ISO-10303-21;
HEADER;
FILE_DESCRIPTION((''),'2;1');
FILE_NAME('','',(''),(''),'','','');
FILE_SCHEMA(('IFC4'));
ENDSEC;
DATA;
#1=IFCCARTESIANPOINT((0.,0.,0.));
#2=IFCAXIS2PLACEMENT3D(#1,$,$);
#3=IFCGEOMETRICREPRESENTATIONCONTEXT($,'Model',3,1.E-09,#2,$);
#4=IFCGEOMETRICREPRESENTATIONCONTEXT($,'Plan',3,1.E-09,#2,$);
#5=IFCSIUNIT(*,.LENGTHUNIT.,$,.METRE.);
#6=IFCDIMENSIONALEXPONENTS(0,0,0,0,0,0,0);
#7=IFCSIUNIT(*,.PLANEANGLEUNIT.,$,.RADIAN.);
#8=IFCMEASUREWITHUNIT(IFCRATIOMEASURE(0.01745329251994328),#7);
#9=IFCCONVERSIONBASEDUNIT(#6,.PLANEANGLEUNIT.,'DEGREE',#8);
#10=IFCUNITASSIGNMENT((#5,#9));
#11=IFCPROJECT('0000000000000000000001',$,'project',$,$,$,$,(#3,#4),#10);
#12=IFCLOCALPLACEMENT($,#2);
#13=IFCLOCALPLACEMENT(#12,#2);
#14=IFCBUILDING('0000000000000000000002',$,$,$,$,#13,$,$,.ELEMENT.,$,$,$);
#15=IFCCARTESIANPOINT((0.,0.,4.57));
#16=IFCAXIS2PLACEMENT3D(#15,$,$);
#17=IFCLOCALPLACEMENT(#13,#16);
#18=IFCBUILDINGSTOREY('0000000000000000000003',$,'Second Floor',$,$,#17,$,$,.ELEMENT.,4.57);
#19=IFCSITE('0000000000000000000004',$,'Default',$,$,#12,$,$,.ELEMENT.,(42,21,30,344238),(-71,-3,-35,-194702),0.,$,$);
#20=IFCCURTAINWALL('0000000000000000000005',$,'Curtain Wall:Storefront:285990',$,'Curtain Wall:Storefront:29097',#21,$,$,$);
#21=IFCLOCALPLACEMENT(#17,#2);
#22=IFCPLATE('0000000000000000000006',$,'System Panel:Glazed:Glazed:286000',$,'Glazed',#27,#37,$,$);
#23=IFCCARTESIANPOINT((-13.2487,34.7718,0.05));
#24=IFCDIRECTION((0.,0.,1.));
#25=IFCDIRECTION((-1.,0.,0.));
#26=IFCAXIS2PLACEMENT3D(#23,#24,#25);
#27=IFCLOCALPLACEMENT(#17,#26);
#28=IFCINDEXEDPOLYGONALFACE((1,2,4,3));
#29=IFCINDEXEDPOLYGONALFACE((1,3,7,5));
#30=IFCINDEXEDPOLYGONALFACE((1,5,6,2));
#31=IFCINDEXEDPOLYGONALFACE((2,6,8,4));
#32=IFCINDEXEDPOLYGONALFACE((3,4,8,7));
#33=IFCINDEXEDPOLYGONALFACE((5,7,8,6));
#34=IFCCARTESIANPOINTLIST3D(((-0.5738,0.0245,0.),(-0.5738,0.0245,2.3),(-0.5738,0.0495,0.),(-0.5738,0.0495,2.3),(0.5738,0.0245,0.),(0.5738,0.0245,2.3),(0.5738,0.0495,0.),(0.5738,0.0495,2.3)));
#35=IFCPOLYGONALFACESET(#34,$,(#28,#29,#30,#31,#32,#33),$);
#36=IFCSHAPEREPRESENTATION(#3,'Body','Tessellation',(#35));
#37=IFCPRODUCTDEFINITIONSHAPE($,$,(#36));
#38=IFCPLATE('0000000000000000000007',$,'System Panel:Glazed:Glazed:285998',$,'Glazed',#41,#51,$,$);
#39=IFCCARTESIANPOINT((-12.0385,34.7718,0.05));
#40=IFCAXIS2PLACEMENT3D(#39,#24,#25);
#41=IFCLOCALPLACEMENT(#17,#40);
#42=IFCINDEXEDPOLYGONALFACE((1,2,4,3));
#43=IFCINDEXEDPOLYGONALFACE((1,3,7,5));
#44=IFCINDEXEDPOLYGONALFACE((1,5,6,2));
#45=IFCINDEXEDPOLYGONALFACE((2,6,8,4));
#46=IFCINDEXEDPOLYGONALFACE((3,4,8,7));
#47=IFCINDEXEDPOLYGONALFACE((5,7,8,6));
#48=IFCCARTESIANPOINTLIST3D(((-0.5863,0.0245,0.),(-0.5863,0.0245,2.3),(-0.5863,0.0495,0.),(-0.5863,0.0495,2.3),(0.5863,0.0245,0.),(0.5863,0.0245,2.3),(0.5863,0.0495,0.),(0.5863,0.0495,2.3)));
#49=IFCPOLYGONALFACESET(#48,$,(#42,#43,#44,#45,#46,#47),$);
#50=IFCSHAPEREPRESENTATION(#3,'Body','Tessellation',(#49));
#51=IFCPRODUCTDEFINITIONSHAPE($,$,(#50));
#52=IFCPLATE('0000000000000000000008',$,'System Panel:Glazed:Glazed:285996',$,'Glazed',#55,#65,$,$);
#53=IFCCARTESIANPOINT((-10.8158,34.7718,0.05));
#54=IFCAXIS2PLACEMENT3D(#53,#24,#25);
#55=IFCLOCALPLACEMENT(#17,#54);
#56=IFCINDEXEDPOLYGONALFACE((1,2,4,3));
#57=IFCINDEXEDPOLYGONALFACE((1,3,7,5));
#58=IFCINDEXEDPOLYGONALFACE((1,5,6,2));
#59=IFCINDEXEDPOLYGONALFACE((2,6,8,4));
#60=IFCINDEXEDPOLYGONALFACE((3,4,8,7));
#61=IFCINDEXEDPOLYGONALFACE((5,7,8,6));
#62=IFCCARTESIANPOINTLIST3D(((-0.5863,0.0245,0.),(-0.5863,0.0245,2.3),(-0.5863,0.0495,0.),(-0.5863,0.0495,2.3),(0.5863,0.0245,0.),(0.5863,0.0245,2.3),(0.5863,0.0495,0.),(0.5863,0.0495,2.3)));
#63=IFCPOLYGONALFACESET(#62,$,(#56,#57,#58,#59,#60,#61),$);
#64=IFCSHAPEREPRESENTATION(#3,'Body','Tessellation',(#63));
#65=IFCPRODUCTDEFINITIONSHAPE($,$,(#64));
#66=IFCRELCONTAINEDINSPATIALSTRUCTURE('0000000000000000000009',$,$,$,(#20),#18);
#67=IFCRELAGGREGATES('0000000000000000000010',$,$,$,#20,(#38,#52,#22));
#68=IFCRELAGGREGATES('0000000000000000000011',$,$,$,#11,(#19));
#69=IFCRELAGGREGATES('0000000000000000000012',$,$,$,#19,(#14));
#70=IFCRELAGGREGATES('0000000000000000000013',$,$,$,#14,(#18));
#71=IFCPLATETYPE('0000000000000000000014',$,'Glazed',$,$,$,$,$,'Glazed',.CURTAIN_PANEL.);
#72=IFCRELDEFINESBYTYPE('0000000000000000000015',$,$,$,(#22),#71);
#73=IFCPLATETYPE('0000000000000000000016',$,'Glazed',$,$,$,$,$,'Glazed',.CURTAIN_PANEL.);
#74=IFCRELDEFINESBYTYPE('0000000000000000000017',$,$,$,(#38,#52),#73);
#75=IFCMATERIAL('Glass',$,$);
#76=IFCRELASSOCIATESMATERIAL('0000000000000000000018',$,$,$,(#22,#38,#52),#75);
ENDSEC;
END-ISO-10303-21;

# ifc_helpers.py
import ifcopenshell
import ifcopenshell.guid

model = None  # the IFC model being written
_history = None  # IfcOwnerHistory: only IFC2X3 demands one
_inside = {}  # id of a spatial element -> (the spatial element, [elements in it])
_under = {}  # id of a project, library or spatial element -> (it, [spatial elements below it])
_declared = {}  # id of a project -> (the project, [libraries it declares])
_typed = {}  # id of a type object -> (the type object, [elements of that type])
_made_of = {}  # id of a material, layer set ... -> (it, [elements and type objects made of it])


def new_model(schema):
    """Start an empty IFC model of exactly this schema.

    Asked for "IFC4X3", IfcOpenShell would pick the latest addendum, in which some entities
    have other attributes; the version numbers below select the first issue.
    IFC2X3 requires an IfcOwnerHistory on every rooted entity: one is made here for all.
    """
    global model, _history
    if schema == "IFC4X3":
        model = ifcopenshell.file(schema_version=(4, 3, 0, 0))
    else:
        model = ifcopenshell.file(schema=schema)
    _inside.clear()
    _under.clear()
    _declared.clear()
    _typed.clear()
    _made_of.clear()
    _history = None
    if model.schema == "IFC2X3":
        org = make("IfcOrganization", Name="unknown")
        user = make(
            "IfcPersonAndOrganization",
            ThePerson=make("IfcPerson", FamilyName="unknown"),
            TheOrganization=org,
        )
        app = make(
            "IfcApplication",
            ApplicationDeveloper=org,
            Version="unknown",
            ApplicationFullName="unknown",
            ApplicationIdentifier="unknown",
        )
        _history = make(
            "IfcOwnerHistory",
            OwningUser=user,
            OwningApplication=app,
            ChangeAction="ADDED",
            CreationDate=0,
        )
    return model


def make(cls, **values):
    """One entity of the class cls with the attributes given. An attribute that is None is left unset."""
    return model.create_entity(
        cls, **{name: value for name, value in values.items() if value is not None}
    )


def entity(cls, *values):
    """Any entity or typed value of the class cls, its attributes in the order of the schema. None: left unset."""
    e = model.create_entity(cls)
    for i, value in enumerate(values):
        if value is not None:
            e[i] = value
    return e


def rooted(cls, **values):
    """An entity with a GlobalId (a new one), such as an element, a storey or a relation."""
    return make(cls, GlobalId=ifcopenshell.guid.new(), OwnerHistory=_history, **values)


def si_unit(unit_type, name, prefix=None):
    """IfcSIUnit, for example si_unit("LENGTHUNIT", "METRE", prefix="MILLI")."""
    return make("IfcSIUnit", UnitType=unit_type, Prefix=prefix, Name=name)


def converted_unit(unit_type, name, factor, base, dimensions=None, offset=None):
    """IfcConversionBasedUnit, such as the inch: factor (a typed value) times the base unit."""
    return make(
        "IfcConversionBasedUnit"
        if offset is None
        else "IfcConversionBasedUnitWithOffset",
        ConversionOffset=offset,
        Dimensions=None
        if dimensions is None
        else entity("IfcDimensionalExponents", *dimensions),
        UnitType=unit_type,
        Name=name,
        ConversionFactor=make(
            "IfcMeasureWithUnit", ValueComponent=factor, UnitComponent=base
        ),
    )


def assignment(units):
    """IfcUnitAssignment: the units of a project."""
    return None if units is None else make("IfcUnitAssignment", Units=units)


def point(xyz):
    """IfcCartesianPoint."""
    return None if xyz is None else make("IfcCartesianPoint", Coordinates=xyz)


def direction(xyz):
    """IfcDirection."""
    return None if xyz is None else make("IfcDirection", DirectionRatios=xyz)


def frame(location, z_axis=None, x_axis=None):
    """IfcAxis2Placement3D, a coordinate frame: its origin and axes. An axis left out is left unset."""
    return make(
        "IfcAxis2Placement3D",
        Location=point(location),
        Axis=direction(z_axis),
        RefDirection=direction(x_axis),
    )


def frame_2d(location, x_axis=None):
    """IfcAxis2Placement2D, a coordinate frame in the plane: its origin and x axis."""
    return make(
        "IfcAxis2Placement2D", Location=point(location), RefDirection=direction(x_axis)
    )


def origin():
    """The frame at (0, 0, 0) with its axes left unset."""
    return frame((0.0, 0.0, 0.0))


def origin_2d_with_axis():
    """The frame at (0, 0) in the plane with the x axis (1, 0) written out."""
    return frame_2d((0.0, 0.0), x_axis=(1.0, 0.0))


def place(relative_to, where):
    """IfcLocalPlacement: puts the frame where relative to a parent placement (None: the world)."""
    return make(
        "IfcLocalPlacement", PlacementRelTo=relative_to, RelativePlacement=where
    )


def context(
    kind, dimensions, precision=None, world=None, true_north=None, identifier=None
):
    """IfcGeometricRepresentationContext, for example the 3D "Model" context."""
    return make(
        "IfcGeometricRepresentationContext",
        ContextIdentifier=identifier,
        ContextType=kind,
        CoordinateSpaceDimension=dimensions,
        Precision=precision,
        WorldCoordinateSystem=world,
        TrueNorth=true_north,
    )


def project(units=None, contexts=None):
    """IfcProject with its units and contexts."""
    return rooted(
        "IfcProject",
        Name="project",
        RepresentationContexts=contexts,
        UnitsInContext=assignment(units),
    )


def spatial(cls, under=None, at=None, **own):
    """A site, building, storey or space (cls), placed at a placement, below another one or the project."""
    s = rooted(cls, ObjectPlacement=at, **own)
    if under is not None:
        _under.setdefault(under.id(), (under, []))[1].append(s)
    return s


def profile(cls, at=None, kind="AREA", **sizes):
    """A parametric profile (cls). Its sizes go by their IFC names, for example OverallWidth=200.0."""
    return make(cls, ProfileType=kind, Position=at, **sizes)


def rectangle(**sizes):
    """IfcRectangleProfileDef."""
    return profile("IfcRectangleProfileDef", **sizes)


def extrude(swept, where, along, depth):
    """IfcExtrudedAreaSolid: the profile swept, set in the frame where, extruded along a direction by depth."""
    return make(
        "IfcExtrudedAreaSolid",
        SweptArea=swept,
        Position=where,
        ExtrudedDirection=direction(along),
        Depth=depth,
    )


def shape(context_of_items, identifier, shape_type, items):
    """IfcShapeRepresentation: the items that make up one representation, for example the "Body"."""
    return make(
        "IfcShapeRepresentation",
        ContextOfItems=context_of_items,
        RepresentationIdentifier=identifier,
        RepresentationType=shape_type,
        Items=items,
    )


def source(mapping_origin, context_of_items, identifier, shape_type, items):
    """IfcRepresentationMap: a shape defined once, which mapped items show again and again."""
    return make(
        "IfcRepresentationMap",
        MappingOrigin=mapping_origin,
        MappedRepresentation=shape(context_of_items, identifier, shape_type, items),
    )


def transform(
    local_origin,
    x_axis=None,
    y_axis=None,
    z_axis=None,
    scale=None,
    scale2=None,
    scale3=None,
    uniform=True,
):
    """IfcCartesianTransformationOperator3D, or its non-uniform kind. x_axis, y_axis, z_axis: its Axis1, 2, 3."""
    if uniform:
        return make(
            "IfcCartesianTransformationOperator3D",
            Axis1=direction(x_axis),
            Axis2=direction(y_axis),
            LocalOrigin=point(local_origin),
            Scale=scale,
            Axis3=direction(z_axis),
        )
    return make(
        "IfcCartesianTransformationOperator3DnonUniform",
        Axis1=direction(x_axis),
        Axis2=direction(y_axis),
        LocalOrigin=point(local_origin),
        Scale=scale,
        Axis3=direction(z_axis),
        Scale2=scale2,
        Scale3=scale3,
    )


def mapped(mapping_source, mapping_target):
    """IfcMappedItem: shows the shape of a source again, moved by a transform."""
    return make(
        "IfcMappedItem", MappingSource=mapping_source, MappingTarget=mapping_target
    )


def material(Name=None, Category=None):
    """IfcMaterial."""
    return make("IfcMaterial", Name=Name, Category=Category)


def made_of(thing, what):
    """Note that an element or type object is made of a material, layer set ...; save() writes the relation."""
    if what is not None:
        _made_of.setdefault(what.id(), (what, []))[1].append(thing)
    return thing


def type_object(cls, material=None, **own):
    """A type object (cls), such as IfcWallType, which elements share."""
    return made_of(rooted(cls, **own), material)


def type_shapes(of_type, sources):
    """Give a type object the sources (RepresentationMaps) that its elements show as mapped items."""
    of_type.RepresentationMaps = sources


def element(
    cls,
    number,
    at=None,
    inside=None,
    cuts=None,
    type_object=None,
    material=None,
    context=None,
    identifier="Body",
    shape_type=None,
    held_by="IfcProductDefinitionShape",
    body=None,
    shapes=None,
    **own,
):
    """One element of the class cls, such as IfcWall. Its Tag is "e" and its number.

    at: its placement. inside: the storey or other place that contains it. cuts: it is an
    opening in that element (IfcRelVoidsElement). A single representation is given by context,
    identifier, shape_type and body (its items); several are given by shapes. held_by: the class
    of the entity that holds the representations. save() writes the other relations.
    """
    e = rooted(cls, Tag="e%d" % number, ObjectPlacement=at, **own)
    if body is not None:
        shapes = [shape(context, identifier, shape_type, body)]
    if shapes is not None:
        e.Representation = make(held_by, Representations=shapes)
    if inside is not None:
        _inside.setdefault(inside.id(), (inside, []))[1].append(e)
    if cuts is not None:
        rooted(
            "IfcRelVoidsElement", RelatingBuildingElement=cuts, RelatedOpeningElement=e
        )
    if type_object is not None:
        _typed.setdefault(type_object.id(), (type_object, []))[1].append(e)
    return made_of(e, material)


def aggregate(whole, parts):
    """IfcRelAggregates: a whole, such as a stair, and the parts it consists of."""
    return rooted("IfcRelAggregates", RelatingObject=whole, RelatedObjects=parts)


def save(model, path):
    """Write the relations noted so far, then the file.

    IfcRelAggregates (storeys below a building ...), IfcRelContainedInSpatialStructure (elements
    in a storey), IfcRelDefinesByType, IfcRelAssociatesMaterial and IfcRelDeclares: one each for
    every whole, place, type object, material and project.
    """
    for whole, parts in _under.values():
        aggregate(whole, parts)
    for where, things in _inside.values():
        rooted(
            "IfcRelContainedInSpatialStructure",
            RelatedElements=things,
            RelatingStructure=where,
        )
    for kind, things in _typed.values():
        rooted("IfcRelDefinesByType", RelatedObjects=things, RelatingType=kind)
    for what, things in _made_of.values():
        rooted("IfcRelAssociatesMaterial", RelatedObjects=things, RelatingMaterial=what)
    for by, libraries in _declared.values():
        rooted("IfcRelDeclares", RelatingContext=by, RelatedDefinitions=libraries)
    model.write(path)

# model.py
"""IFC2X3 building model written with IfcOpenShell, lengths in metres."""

from ifc_helpers import new_model, entity, si_unit, converted_unit, frame, origin, origin_2d_with_axis, place, context, project, spatial, rectangle, extrude, source, transform, mapped, material, type_object, type_shapes, element, aggregate, save


model = new_model("IFC2X3")

# Units and contexts
model_context = context("Model", 3, precision=1e-09, world=origin())
plan_context = context("Plan", 3, precision=1e-09, world=origin())
ifc_project = project(units=[si_unit("LENGTHUNIT", "METRE"), converted_unit("PLANEANGLEUNIT", "DEGREE", entity("IfcRatioMeasure", 0.01745329251994328), si_unit("PLANEANGLEUNIT", "RADIAN"), dimensions=[0, 0, 0, 0, 0, 0, 0])], contexts=[model_context, plan_context])

# Site, building, storey
site_placement = place(None, origin())
site = spatial("IfcSite", under=ifc_project, at=site_placement, Name="Default", CompositionType="ELEMENT", RefLatitude=(42, 21, 30, 344238), RefLongitude=(-71, -3, -35, -194702), RefElevation=0.0)
building_placement = place(site_placement, origin())
building = spatial("IfcBuilding", under=site, at=building_placement, CompositionType="ELEMENT")
storey_placement = place(building_placement, frame((0.0, 0.0, 4.57)))
storey = spatial("IfcBuildingStorey", under=building, at=storey_placement, Name="Second Floor", CompositionType="ELEMENT", Elevation=4.57)

# Curtain wall, plates
curtain_wall_placement = place(storey_placement, origin())
curtain_wall = element("IfcCurtainWall", 1, at=curtain_wall_placement, inside=storey, Name="Curtain Wall:Storefront:285990", ObjectType="Curtain Wall:Storefront:29097")
ifc_material_1 = material(Name="Glass")
plate_type_1 = type_object("IfcPlateType", Name="Glazed", ElementType="Glazed", PredefinedType="CURTAIN_PANEL")
shared_shape_1 = source(origin(), model_context, "Body", "SweptSolid", [
    extrude(rectangle(XDim=0.025, YDim=1.1477, at=origin_2d_with_axis()), frame((0.0, 0.037, 0.0), z_axis=(0.0, 0.0, 1.0), x_axis=(0.0, 1.0, 0.0)), (0.0, 0.0, 1.0), 2.3),
])
type_shapes(plate_type_1, [shared_shape_1])
plate_1_placement = place(storey_placement, frame((-13.2487, 34.7718, 0.05), z_axis=(0.0, 0.0, 1.0), x_axis=(-1.0, 0.0, 0.0)))
plate_1 = element("IfcPlate", 2, at=plate_1_placement, type_object=plate_type_1, material=ifc_material_1, Name="System Panel:Glazed:Glazed:286000", ObjectType="Glazed", context=model_context, shape_type="MappedRepresentation", body=[
    mapped(shared_shape_1, transform((0.0, 0.0, 0.0), scale=1.0)),
])
plate_type_2 = type_object("IfcPlateType", Name="Glazed", ElementType="Glazed", PredefinedType="CURTAIN_PANEL")
shared_shape_2 = source(origin(), model_context, "Body", "SweptSolid", [
    extrude(rectangle(XDim=0.025, YDim=1.1727, at=origin_2d_with_axis()), frame((0.0, 0.037, 0.0), z_axis=(0.0, 0.0, 1.0), x_axis=(0.0, 1.0, 0.0)), (0.0, 0.0, 1.0), 2.3),
])
type_shapes(plate_type_2, [shared_shape_2])
plate_2_placement = place(storey_placement, frame((-12.0385, 34.7718, 0.05), z_axis=(0.0, 0.0, 1.0), x_axis=(-1.0, 0.0, 0.0)))
plate_2 = element("IfcPlate", 3, at=plate_2_placement, type_object=plate_type_2, material=ifc_material_1, Name="System Panel:Glazed:Glazed:285998", ObjectType="Glazed", context=model_context, shape_type="MappedRepresentation", body=[
    mapped(shared_shape_2, transform((0.0, 0.0, 0.0), scale=1.0)),
])
plate_3_placement = place(storey_placement, frame((-10.8158, 34.7718, 0.05), z_axis=(0.0, 0.0, 1.0), x_axis=(-1.0, 0.0, 0.0)))
plate_3 = element("IfcPlate", 4, at=plate_3_placement, type_object=plate_type_2, material=ifc_material_1, Name="System Panel:Glazed:Glazed:285996", ObjectType="Glazed", context=model_context, shape_type="MappedRepresentation", body=[
    mapped(shared_shape_2, transform((0.0, 0.0, 0.0), scale=1.0)),
])
aggregate(curtain_wall, [plate_2, plate_3, plate_1])

save(model, "model.ifc")
